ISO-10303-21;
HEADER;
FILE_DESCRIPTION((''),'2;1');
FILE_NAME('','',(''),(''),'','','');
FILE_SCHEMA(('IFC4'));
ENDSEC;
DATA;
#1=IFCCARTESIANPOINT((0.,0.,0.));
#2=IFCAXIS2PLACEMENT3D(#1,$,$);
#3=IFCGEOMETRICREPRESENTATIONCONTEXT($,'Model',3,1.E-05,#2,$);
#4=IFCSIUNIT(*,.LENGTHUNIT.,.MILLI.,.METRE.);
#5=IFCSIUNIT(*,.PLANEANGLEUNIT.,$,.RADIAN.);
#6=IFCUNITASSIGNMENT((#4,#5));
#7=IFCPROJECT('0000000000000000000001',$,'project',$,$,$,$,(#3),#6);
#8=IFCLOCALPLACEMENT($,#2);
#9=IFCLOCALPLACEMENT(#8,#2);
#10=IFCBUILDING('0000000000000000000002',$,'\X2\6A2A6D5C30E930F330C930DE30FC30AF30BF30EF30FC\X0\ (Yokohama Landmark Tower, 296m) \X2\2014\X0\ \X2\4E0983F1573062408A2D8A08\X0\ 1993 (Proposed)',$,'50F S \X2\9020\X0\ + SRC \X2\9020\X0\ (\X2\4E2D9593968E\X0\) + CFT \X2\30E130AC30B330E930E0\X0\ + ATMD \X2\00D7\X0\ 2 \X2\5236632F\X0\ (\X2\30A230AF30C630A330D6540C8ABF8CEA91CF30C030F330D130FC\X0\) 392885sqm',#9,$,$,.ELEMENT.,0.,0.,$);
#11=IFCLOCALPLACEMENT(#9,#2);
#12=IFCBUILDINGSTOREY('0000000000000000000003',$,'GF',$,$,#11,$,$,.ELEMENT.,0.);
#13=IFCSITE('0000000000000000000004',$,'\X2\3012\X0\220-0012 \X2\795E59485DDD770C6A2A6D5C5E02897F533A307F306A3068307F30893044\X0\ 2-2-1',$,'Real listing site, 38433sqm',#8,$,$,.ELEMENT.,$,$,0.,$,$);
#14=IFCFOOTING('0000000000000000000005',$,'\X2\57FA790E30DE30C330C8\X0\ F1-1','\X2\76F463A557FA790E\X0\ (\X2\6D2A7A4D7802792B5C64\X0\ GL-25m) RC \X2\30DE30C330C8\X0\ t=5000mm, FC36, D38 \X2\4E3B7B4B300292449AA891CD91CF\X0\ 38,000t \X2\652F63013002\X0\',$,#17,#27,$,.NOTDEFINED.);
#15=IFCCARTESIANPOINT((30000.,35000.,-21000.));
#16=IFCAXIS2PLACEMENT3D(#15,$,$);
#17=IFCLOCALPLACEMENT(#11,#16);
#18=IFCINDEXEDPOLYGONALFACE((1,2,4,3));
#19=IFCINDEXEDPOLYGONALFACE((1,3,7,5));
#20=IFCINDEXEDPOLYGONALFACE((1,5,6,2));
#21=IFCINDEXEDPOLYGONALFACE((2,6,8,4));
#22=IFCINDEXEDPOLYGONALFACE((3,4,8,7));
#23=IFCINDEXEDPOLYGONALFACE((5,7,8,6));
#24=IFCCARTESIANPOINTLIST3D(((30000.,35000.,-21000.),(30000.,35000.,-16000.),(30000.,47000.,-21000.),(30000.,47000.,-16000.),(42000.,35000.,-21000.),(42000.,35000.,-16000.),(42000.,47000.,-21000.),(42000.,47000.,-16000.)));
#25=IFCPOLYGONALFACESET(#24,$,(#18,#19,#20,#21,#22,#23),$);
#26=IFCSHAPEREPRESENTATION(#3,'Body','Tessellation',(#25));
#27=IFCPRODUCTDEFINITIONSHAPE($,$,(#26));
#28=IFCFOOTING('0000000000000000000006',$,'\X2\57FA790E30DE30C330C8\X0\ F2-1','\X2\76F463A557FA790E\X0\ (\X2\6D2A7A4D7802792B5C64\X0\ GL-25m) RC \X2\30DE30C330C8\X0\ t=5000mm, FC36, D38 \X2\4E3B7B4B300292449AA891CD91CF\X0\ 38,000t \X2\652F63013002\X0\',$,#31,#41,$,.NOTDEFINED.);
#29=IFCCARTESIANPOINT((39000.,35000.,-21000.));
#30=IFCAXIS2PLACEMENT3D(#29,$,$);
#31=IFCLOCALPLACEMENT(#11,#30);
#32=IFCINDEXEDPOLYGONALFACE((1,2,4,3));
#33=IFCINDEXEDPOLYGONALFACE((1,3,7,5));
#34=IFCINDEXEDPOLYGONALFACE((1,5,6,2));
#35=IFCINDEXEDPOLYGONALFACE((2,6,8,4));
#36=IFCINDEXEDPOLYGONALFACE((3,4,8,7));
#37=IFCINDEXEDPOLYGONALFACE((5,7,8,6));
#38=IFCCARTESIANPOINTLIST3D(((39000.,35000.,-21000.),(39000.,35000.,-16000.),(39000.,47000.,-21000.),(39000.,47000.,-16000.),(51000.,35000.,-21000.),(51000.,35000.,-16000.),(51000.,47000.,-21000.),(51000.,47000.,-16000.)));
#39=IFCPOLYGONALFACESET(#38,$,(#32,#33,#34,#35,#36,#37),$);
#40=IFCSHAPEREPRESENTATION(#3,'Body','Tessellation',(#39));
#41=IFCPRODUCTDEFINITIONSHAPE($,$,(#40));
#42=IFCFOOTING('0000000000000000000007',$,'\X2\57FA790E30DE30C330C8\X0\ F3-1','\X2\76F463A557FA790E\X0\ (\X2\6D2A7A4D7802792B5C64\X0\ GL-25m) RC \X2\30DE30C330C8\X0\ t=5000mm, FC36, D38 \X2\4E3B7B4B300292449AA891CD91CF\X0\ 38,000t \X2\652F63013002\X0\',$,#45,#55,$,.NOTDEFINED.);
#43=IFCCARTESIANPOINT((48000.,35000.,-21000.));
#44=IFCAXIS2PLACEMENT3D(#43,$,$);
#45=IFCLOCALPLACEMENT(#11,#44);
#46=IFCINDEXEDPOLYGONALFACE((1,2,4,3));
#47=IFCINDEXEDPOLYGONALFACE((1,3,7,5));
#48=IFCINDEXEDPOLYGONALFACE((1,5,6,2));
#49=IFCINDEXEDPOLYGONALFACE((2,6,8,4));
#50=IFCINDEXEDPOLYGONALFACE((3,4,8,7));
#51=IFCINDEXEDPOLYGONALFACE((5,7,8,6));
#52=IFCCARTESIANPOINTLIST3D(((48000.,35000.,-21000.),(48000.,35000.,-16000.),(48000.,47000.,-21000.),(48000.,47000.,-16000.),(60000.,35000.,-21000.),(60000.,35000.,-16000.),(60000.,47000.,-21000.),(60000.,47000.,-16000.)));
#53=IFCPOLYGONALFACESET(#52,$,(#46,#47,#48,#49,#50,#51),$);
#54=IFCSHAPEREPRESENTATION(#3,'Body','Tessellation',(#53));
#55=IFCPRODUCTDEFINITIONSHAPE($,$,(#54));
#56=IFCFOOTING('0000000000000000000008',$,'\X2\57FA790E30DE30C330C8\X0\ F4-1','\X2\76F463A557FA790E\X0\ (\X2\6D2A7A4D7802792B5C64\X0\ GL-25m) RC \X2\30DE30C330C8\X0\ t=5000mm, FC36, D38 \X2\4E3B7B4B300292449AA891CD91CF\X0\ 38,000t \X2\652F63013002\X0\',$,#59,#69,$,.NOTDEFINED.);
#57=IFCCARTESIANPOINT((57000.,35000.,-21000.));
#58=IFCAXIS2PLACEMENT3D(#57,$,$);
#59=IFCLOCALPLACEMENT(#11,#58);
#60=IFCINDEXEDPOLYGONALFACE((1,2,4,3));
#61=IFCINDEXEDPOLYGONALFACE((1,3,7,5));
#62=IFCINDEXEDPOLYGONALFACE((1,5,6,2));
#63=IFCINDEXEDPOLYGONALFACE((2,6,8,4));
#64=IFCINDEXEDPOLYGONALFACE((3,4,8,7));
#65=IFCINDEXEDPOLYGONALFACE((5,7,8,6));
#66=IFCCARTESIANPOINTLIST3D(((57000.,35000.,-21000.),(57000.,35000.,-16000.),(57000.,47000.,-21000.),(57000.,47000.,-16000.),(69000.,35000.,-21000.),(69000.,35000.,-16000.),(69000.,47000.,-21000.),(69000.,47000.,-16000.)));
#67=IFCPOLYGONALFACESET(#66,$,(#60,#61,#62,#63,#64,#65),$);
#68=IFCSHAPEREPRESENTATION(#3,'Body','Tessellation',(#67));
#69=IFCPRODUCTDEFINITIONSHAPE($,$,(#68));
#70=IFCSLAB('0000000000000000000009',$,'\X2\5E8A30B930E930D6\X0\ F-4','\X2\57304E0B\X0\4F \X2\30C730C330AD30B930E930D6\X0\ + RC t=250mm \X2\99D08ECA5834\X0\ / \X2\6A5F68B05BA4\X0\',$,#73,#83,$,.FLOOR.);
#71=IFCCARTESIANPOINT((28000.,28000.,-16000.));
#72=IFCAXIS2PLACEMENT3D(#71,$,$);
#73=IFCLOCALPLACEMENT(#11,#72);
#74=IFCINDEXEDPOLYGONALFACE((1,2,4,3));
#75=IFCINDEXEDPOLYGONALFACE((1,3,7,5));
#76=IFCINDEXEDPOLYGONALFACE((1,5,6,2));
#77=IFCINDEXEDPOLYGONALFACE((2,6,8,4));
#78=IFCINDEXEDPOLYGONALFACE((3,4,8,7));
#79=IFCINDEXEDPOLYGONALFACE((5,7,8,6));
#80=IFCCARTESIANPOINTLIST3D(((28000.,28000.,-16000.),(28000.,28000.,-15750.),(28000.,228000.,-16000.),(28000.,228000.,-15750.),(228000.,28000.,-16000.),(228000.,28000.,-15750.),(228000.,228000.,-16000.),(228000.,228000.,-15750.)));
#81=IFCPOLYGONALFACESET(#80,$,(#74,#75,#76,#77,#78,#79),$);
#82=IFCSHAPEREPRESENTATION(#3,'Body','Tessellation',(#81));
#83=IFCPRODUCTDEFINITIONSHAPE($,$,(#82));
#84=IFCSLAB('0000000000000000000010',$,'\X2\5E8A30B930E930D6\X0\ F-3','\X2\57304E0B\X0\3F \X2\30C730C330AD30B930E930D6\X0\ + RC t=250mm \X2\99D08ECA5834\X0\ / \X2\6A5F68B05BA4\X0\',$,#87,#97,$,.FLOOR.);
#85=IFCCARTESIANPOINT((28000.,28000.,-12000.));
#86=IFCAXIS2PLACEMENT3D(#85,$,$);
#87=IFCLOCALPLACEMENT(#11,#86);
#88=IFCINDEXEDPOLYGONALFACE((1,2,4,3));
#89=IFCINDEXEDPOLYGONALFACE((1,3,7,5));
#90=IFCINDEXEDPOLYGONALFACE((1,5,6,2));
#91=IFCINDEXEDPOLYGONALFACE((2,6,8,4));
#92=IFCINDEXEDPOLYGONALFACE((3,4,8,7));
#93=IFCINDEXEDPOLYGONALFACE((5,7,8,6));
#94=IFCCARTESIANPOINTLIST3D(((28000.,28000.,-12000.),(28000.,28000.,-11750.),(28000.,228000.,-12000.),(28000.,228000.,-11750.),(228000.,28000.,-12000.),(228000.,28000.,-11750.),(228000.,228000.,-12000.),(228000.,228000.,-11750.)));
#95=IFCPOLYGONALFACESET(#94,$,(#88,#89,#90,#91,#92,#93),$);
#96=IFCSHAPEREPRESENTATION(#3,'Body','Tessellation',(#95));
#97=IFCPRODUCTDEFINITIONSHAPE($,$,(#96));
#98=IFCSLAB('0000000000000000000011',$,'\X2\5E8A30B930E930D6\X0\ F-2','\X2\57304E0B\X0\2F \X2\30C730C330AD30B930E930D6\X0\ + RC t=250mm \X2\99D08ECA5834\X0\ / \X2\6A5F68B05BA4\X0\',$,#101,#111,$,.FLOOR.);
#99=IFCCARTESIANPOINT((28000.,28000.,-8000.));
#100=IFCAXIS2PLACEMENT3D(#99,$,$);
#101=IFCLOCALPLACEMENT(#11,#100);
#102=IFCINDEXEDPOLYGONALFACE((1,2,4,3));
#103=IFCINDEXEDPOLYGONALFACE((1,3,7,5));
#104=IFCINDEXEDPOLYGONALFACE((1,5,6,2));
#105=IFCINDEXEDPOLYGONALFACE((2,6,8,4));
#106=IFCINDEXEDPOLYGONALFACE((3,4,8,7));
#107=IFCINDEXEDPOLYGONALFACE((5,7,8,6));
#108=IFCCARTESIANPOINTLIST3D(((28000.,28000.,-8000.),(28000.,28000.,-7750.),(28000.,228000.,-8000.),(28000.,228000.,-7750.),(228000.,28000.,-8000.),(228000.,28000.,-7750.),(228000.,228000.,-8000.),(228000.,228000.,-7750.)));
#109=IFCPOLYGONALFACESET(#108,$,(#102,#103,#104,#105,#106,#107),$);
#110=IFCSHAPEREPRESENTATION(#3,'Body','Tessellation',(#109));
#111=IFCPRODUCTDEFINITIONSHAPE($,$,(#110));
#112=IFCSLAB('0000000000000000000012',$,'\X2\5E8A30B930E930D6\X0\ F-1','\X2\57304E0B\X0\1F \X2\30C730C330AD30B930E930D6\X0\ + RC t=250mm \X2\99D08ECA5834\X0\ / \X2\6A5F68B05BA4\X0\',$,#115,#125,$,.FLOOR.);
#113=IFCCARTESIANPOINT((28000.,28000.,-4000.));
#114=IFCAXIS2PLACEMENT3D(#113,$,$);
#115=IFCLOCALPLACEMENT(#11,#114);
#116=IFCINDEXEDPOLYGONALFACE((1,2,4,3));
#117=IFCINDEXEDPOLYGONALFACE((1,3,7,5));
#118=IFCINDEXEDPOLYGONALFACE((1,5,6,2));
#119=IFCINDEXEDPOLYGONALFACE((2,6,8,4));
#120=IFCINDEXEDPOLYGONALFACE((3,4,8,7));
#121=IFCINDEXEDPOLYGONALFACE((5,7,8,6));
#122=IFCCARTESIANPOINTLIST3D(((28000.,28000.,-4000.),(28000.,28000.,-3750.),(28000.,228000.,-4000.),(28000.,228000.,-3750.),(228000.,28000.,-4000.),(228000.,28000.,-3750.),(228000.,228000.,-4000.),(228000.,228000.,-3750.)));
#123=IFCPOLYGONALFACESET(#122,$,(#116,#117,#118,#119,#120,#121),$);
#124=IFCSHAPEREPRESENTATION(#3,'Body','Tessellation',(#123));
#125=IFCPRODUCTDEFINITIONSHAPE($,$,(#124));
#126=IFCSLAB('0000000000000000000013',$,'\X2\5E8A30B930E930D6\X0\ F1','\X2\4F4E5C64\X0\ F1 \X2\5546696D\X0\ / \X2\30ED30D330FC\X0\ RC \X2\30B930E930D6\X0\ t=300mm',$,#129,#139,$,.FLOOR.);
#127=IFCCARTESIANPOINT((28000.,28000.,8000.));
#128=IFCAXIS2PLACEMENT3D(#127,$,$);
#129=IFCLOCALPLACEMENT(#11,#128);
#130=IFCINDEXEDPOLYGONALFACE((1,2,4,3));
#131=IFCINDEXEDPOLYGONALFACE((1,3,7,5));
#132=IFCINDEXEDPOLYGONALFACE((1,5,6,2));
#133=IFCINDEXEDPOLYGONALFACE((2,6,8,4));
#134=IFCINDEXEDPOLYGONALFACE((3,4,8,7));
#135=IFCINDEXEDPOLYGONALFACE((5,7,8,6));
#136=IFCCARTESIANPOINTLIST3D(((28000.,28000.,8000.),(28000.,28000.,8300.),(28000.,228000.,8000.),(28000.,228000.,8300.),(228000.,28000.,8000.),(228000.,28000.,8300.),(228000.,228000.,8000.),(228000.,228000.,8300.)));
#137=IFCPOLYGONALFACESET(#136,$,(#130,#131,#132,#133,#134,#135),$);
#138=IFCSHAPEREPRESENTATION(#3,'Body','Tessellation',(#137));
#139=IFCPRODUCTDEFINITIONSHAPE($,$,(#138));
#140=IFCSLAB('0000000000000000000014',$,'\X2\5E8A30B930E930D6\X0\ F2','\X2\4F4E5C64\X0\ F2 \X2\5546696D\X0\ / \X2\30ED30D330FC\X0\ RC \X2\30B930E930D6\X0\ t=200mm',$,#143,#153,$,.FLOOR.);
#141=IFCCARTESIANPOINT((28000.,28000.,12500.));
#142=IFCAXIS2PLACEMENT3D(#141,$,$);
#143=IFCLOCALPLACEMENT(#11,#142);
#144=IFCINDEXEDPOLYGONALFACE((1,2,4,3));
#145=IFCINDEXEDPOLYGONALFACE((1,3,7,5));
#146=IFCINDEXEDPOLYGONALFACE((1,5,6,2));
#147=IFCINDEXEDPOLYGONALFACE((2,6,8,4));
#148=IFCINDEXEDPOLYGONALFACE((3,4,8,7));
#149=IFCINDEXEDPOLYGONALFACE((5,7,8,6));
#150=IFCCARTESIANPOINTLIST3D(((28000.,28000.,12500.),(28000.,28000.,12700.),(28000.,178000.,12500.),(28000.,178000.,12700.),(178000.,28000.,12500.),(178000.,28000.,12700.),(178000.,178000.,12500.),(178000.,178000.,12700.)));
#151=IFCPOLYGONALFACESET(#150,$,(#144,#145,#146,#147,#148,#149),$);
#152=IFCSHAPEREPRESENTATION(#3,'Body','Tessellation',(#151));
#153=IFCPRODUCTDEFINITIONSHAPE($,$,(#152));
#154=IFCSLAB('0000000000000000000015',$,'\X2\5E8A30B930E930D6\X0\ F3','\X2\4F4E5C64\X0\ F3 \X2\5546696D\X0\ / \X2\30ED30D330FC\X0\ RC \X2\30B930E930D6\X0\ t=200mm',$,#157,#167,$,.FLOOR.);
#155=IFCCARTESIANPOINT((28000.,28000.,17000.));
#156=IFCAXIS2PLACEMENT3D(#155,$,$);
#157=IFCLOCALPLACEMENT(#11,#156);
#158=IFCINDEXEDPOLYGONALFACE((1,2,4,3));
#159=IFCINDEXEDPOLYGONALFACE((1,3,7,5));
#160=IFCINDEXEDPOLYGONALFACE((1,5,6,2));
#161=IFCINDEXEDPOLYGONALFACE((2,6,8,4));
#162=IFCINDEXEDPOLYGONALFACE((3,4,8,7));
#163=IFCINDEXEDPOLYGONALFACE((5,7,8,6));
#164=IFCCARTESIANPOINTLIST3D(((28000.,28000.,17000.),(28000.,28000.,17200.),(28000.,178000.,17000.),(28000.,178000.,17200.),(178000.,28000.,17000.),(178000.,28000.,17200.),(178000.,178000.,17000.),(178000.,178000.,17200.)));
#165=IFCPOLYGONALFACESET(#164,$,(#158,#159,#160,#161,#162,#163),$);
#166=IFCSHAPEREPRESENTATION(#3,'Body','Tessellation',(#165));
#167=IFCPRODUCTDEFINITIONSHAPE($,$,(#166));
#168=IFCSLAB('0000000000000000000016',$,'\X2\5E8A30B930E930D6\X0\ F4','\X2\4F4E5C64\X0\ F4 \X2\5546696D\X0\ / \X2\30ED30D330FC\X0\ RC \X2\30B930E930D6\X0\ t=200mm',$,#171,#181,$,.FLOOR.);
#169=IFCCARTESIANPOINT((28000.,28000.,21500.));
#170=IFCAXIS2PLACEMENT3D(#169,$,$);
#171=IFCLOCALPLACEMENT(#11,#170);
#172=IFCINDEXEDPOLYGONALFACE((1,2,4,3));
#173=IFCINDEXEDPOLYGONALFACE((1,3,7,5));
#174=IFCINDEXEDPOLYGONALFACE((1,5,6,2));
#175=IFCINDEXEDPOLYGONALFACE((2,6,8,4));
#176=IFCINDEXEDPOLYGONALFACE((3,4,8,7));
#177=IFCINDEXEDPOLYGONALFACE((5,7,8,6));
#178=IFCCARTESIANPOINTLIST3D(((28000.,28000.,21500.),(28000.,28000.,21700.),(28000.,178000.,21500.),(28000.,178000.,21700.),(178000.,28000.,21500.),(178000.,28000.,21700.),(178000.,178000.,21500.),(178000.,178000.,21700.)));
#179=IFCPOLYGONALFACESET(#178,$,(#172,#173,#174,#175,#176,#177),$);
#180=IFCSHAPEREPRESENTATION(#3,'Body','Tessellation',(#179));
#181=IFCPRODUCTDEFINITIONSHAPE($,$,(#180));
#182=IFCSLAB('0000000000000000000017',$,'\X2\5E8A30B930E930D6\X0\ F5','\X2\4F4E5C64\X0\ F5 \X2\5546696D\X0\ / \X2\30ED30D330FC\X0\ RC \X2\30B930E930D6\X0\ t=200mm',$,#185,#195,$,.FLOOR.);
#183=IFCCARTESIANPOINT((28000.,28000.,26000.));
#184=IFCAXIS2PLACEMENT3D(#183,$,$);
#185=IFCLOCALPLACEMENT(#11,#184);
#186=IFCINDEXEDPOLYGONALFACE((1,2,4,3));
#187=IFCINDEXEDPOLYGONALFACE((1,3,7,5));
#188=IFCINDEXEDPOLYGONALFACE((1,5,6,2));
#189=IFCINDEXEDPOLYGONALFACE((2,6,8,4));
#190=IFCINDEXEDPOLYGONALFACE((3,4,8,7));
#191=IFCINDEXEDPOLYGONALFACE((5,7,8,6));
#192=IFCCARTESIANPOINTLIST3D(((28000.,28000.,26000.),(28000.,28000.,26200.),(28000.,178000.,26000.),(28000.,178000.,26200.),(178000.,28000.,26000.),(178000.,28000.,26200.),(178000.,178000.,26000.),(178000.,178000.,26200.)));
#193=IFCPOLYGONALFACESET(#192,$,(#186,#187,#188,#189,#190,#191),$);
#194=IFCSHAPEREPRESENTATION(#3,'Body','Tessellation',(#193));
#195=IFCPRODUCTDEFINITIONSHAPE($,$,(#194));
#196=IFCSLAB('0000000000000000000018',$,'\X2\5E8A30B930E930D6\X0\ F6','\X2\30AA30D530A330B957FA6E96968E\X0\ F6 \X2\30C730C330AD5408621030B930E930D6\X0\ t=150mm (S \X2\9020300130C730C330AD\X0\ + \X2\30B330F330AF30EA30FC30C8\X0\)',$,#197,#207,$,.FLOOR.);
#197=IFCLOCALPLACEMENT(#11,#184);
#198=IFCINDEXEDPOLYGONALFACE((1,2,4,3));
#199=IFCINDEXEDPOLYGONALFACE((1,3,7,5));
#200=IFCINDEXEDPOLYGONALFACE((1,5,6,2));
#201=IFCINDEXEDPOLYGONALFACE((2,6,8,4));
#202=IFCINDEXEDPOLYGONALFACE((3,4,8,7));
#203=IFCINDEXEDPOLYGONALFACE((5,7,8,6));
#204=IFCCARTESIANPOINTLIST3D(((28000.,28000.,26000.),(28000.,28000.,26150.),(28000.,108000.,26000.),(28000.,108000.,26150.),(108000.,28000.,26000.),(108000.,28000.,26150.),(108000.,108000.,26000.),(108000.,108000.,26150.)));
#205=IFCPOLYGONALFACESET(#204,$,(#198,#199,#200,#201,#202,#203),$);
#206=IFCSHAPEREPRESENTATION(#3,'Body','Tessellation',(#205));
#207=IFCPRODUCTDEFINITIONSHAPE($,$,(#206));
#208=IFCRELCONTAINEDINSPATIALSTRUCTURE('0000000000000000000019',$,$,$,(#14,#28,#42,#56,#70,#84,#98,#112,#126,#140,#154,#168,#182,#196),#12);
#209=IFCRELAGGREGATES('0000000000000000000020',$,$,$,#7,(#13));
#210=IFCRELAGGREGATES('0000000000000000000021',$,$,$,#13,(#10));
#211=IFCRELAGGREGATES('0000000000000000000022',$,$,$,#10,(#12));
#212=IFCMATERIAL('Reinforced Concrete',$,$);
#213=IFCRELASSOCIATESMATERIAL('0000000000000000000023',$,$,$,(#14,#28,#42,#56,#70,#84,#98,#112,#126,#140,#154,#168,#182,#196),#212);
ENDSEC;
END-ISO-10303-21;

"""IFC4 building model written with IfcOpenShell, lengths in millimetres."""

from ifc_helpers import new_model, si_unit, frame, frame_2d, origin, place, context, project, spatial, rectangle, extrude, material, element, save


model = new_model("IFC4")

# Units and contexts
model_context = context("Model", 3, precision=1e-05, world=origin())
ifc_project = project(units=[si_unit("LENGTHUNIT", "METRE", prefix="MILLI"), si_unit("PLANEANGLEUNIT", "RADIAN")], contexts=[model_context])

# Site, building, storey
site_placement = place(None, origin())
site = spatial("IfcSite", under=ifc_project, at=site_placement, Name="〒220-0012 神奈川県横浜市西区みなとみらい 2-2-1", ObjectType="Real listing site, 38433sqm", CompositionType="ELEMENT", RefElevation=0.0)
building_placement = place(site_placement, origin())
building = spatial("IfcBuilding", under=site, at=building_placement, Name="横浜ランドマークタワー (Yokohama Landmark Tower, 296m) — 三菱地所設計 1993 (Proposed)", ObjectType="50F S 造 + SRC 造 (中間階) + CFT メガコラム + ATMD × 2 制振 (アクティブ同調質量ダンパー) 392885sqm", CompositionType="ELEMENT", ElevationOfRefHeight=0.0, ElevationOfTerrain=0.0)
storey_placement = place(building_placement, origin())
storey = spatial("IfcBuildingStorey", under=building, at=storey_placement, Name="GF", CompositionType="ELEMENT", Elevation=0.0)

# Footings
ifc_material_1 = material(Name="Reinforced Concrete")
footing_1_placement = place(storey_placement, frame((30000.0, 35000.0, -21000.0)))
element("IfcFooting", 1, at=footing_1_placement, inside=storey, material=ifc_material_1, Name="基礎マット F1-1", Description="直接基礎 (洪積砂礫層 GL-25m) RC マット t=5000mm, FC36, D38 主筋。鉄骨重量 38,000t 支持。", PredefinedType="NOTDEFINED", context=model_context, shape_type="SweptSolid", body=[
    extrude(rectangle(XDim=12000.0, YDim=12000.0, at=frame_2d((6000.0, 6000.0))), frame((30000.0, 35000.0, -21000.0)), (0.0, 0.0, 1.0), 5000.0),
])
footing_2_placement = place(storey_placement, frame((39000.0, 35000.0, -21000.0)))
element("IfcFooting", 2, at=footing_2_placement, inside=storey, material=ifc_material_1, Name="基礎マット F2-1", Description="直接基礎 (洪積砂礫層 GL-25m) RC マット t=5000mm, FC36, D38 主筋。鉄骨重量 38,000t 支持。", PredefinedType="NOTDEFINED", context=model_context, shape_type="SweptSolid", body=[
    extrude(rectangle(XDim=12000.0, YDim=12000.0, at=frame_2d((6000.0, 6000.0))), frame((39000.0, 35000.0, -21000.0)), (0.0, 0.0, 1.0), 5000.0),
])
footing_3_placement = place(storey_placement, frame((48000.0, 35000.0, -21000.0)))
element("IfcFooting", 3, at=footing_3_placement, inside=storey, material=ifc_material_1, Name="基礎マット F3-1", Description="直接基礎 (洪積砂礫層 GL-25m) RC マット t=5000mm, FC36, D38 主筋。鉄骨重量 38,000t 支持。", PredefinedType="NOTDEFINED", context=model_context, shape_type="SweptSolid", body=[
    extrude(rectangle(XDim=12000.0, YDim=12000.0, at=frame_2d((6000.0, 6000.0))), frame((48000.0, 35000.0, -21000.0)), (0.0, 0.0, 1.0), 5000.0),
])
footing_4_placement = place(storey_placement, frame((57000.0, 35000.0, -21000.0)))
element("IfcFooting", 4, at=footing_4_placement, inside=storey, material=ifc_material_1, Name="基礎マット F4-1", Description="直接基礎 (洪積砂礫層 GL-25m) RC マット t=5000mm, FC36, D38 主筋。鉄骨重量 38,000t 支持。", PredefinedType="NOTDEFINED", context=model_context, shape_type="SweptSolid", body=[
    extrude(rectangle(XDim=12000.0, YDim=12000.0, at=frame_2d((6000.0, 6000.0))), frame((57000.0, 35000.0, -21000.0)), (0.0, 0.0, 1.0), 5000.0),
])

# Slabs
slab_1_placement = place(storey_placement, frame((28000.0, 28000.0, -16000.0)))
element("IfcSlab", 5, at=slab_1_placement, inside=storey, material=ifc_material_1, Name="床スラブ F-4", Description="地下4F デッキスラブ + RC t=250mm 駐車場 / 機械室", PredefinedType="FLOOR", context=model_context, shape_type="SweptSolid", body=[
    extrude(rectangle(XDim=200000.0, YDim=200000.0, at=frame_2d((100000.0, 100000.0))), frame((28000.0, 28000.0, -16000.0)), (0.0, 0.0, 1.0), 250.0),
])
slab_2_placement = place(storey_placement, frame((28000.0, 28000.0, -12000.0)))
element("IfcSlab", 6, at=slab_2_placement, inside=storey, material=ifc_material_1, Name="床スラブ F-3", Description="地下3F デッキスラブ + RC t=250mm 駐車場 / 機械室", PredefinedType="FLOOR", context=model_context, shape_type="SweptSolid", body=[
    extrude(rectangle(XDim=200000.0, YDim=200000.0, at=frame_2d((100000.0, 100000.0))), frame((28000.0, 28000.0, -12000.0)), (0.0, 0.0, 1.0), 250.0),
])
slab_3_placement = place(storey_placement, frame((28000.0, 28000.0, -8000.0)))
element("IfcSlab", 7, at=slab_3_placement, inside=storey, material=ifc_material_1, Name="床スラブ F-2", Description="地下2F デッキスラブ + RC t=250mm 駐車場 / 機械室", PredefinedType="FLOOR", context=model_context, shape_type="SweptSolid", body=[
    extrude(rectangle(XDim=200000.0, YDim=200000.0, at=frame_2d((100000.0, 100000.0))), frame((28000.0, 28000.0, -8000.0)), (0.0, 0.0, 1.0), 250.0),
])
slab_4_placement = place(storey_placement, frame((28000.0, 28000.0, -4000.0)))
element("IfcSlab", 8, at=slab_4_placement, inside=storey, material=ifc_material_1, Name="床スラブ F-1", Description="地下1F デッキスラブ + RC t=250mm 駐車場 / 機械室", PredefinedType="FLOOR", context=model_context, shape_type="SweptSolid", body=[
    extrude(rectangle(XDim=200000.0, YDim=200000.0, at=frame_2d((100000.0, 100000.0))), frame((28000.0, 28000.0, -4000.0)), (0.0, 0.0, 1.0), 250.0),
])
slab_5_placement = place(storey_placement, frame((28000.0, 28000.0, 8000.0)))
element("IfcSlab", 9, at=slab_5_placement, inside=storey, material=ifc_material_1, Name="床スラブ F1", Description="低層 F1 商業 / ロビー RC スラブ t=300mm", PredefinedType="FLOOR", context=model_context, shape_type="SweptSolid", body=[
    extrude(rectangle(XDim=200000.0, YDim=200000.0, at=frame_2d((100000.0, 100000.0))), frame((28000.0, 28000.0, 8000.0)), (0.0, 0.0, 1.0), 300.0),
])
slab_6_placement = place(storey_placement, frame((28000.0, 28000.0, 12500.0)))
element("IfcSlab", 10, at=slab_6_placement, inside=storey, material=ifc_material_1, Name="床スラブ F2", Description="低層 F2 商業 / ロビー RC スラブ t=200mm", PredefinedType="FLOOR", context=model_context, shape_type="SweptSolid", body=[
    extrude(rectangle(XDim=150000.0, YDim=150000.0, at=frame_2d((75000.0, 75000.0))), frame((28000.0, 28000.0, 12500.0)), (0.0, 0.0, 1.0), 200.0),
])
slab_7_placement = place(storey_placement, frame((28000.0, 28000.0, 17000.0)))
element("IfcSlab", 11, at=slab_7_placement, inside=storey, material=ifc_material_1, Name="床スラブ F3", Description="低層 F3 商業 / ロビー RC スラブ t=200mm", PredefinedType="FLOOR", context=model_context, shape_type="SweptSolid", body=[
    extrude(rectangle(XDim=150000.0, YDim=150000.0, at=frame_2d((75000.0, 75000.0))), frame((28000.0, 28000.0, 17000.0)), (0.0, 0.0, 1.0), 200.0),
])
slab_8_placement = place(storey_placement, frame((28000.0, 28000.0, 21500.0)))
element("IfcSlab", 12, at=slab_8_placement, inside=storey, material=ifc_material_1, Name="床スラブ F4", Description="低層 F4 商業 / ロビー RC スラブ t=200mm", PredefinedType="FLOOR", context=model_context, shape_type="SweptSolid", body=[
    extrude(rectangle(XDim=150000.0, YDim=150000.0, at=frame_2d((75000.0, 75000.0))), frame((28000.0, 28000.0, 21500.0)), (0.0, 0.0, 1.0), 200.0),
])
slab_9_placement = place(storey_placement, frame((28000.0, 28000.0, 26000.0)))
element("IfcSlab", 13, at=slab_9_placement, inside=storey, material=ifc_material_1, Name="床スラブ F5", Description="低層 F5 商業 / ロビー RC スラブ t=200mm", PredefinedType="FLOOR", context=model_context, shape_type="SweptSolid", body=[
    extrude(rectangle(XDim=150000.0, YDim=150000.0, at=frame_2d((75000.0, 75000.0))), frame((28000.0, 28000.0, 26000.0)), (0.0, 0.0, 1.0), 200.0),
])
slab_10_placement = place(storey_placement, frame((28000.0, 28000.0, 26000.0)))
element("IfcSlab", 14, at=slab_10_placement, inside=storey, material=ifc_material_1, Name="床スラブ F6", Description="オフィス基準階 F6 デッキ合成スラブ t=150mm (S 造、デッキ + コンクリート)", PredefinedType="FLOOR", context=model_context, shape_type="SweptSolid", body=[
    extrude(rectangle(XDim=80000.0, YDim=80000.0, at=frame_2d((40000.0, 40000.0))), frame((28000.0, 28000.0, 26000.0)), (0.0, 0.0, 1.0), 150.0),
])

save(model, "model.ifc")
